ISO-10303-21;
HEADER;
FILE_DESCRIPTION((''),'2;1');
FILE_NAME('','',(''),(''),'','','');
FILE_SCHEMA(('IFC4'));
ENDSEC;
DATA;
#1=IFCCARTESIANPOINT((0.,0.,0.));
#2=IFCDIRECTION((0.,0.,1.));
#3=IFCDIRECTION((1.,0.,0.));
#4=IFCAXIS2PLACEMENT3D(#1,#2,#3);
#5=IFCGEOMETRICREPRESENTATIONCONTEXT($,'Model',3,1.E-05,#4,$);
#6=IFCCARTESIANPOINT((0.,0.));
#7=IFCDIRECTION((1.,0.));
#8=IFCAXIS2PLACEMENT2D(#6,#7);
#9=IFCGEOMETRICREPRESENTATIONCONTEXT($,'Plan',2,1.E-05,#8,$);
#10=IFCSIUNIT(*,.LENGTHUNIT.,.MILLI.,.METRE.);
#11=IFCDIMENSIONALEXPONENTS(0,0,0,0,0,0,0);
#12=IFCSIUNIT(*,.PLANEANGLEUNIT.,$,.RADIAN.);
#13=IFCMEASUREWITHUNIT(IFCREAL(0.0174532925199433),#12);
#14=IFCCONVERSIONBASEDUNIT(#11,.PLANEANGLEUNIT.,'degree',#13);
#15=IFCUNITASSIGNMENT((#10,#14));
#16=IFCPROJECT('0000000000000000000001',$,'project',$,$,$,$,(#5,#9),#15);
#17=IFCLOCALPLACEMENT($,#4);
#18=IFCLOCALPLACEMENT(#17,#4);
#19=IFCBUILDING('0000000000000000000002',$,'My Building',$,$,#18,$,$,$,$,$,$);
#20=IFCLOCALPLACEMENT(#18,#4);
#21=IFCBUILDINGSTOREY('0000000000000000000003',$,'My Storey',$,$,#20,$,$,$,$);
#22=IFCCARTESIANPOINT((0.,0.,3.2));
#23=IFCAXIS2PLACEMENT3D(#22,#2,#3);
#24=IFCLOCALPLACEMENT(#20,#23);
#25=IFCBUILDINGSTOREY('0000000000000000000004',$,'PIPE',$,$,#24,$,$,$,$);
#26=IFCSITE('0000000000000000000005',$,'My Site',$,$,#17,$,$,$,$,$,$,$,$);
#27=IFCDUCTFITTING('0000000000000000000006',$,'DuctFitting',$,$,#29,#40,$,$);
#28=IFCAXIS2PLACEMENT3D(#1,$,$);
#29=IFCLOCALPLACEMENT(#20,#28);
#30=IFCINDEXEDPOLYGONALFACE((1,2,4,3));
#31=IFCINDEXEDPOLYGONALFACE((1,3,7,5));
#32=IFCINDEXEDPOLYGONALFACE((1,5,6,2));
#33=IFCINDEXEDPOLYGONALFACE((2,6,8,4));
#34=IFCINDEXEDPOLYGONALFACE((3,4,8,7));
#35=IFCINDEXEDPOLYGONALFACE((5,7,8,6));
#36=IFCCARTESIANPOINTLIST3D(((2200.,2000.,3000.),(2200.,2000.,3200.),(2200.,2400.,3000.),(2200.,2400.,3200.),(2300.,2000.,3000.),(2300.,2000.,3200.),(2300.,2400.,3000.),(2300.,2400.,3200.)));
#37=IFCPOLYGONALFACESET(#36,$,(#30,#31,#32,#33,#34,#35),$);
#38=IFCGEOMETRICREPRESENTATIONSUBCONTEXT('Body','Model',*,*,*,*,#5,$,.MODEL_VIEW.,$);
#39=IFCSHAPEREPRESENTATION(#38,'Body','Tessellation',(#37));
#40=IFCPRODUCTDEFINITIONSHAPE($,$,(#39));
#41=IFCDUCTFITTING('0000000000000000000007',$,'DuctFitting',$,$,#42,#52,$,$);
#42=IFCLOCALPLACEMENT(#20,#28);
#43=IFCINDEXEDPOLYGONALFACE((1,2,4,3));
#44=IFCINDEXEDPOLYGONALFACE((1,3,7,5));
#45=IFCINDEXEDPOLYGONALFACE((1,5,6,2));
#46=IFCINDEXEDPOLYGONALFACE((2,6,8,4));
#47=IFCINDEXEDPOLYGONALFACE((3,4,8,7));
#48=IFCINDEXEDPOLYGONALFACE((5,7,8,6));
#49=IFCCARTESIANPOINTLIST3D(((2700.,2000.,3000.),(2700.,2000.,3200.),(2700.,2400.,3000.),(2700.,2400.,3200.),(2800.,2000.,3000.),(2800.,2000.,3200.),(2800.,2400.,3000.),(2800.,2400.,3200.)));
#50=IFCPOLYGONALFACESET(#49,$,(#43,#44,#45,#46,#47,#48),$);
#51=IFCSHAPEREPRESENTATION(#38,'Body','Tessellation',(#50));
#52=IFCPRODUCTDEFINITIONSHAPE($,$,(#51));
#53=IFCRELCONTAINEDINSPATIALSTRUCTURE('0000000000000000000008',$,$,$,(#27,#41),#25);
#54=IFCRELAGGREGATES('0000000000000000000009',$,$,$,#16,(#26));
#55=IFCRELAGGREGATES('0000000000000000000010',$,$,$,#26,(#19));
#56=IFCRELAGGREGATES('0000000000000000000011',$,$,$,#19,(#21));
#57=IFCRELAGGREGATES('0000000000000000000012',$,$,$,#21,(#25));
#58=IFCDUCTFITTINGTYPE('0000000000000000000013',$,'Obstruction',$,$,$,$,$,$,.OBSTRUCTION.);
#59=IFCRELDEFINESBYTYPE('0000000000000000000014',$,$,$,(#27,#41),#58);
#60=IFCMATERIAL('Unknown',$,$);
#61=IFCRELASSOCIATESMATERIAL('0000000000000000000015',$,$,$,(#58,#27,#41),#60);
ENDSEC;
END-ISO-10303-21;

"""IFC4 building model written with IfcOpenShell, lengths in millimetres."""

from ifc_helpers import new_model, entity, si_unit, converted_unit, frame, origin_with_axes, origin_2d_with_axis, place, context, subcontext, project, spatial, rectangle, extrude, material, material_profile, profile_set, profile_usage, type_object, element, save


model = new_model("IFC4")

# Units and contexts
model_context = context("Model", 3, precision=1e-05, world=origin_with_axes())
plan_context = context("Plan", 2, precision=1e-05, world=origin_2d_with_axis())
body_context = subcontext(model_context, "Body", "Model", "MODEL_VIEW")
ifc_project = project(units=[si_unit("LENGTHUNIT", "METRE", prefix="MILLI"), converted_unit("PLANEANGLEUNIT", "degree", entity("IfcReal", 0.0174532925199433), si_unit("PLANEANGLEUNIT", "RADIAN"), dimensions=[0, 0, 0, 0, 0, 0, 0])], contexts=[model_context, plan_context])

# Site, building, storeys
site_placement = place(None, origin_with_axes())
site = spatial("IfcSite", under=ifc_project, at=site_placement, Name="My Site")
building_placement = place(site_placement, origin_with_axes())
building = spatial("IfcBuilding", under=site, at=building_placement, Name="My Building")
storey_1_placement = place(building_placement, origin_with_axes())
storey_1 = spatial("IfcBuildingStorey", under=building, at=storey_1_placement, Name="My Storey")
storey_2_placement = place(storey_1_placement, frame((0.0, 0.0, 3.2), z_axis=(0.0, 0.0, 1.0), x_axis=(1.0, 0.0, 0.0)))
storey_2 = spatial("IfcBuildingStorey", under=storey_1, at=storey_2_placement, Name="PIPE")

# Shared definitions
ifc_material = material(Name="Unknown")

# Duct fittings
ifc_material_profile_1 = material_profile(ifc_material, rectangle(XDim=400.0, YDim=200.0))
ifc_profile_set_1 = profile_set([ifc_material_profile_1])
ifc_profile_usage_1 = profile_usage(ifc_profile_set_1, cardinal=10)
duct_fitting_type = type_object("IfcDuctFittingType", Name="Obstruction", PredefinedType="OBSTRUCTION", material=ifc_profile_set_1)
duct_fitting_1_placement = place(storey_2_placement, frame((2300.0, 2200.0, 3096.8), z_axis=(-1.0, 0.0, 0.0), x_axis=(0.0, -1.0, 0.0)))
element("IfcDuctFitting", 1, at=duct_fitting_1_placement, inside=storey_2, type_object=duct_fitting_type, material=ifc_profile_usage_1, Name="DuctFitting", context=body_context, shape_type="SweptSolid", body=[
    extrude(rectangle(XDim=400.0, YDim=200.0), origin_with_axes(), (0.0, 0.0, 1.0), 100.0),
])
ifc_profile_usage_2 = profile_usage(ifc_profile_set_1, cardinal=10)
duct_fitting_2_placement = place(storey_2_placement, frame((2700.0, 2200.0, 3096.8), z_axis=(1.0, 0.0, 0.0), x_axis=(0.0, 1.0, 0.0)))
element("IfcDuctFitting", 2, at=duct_fitting_2_placement, inside=storey_2, type_object=duct_fitting_type, material=ifc_profile_usage_2, Name="DuctFitting", context=body_context, shape_type="SweptSolid", body=[
    extrude(rectangle(XDim=400.0, YDim=200.0), origin_with_axes(), (0.0, 0.0, 1.0), 100.0),
])

save(model, "model.ifc")
